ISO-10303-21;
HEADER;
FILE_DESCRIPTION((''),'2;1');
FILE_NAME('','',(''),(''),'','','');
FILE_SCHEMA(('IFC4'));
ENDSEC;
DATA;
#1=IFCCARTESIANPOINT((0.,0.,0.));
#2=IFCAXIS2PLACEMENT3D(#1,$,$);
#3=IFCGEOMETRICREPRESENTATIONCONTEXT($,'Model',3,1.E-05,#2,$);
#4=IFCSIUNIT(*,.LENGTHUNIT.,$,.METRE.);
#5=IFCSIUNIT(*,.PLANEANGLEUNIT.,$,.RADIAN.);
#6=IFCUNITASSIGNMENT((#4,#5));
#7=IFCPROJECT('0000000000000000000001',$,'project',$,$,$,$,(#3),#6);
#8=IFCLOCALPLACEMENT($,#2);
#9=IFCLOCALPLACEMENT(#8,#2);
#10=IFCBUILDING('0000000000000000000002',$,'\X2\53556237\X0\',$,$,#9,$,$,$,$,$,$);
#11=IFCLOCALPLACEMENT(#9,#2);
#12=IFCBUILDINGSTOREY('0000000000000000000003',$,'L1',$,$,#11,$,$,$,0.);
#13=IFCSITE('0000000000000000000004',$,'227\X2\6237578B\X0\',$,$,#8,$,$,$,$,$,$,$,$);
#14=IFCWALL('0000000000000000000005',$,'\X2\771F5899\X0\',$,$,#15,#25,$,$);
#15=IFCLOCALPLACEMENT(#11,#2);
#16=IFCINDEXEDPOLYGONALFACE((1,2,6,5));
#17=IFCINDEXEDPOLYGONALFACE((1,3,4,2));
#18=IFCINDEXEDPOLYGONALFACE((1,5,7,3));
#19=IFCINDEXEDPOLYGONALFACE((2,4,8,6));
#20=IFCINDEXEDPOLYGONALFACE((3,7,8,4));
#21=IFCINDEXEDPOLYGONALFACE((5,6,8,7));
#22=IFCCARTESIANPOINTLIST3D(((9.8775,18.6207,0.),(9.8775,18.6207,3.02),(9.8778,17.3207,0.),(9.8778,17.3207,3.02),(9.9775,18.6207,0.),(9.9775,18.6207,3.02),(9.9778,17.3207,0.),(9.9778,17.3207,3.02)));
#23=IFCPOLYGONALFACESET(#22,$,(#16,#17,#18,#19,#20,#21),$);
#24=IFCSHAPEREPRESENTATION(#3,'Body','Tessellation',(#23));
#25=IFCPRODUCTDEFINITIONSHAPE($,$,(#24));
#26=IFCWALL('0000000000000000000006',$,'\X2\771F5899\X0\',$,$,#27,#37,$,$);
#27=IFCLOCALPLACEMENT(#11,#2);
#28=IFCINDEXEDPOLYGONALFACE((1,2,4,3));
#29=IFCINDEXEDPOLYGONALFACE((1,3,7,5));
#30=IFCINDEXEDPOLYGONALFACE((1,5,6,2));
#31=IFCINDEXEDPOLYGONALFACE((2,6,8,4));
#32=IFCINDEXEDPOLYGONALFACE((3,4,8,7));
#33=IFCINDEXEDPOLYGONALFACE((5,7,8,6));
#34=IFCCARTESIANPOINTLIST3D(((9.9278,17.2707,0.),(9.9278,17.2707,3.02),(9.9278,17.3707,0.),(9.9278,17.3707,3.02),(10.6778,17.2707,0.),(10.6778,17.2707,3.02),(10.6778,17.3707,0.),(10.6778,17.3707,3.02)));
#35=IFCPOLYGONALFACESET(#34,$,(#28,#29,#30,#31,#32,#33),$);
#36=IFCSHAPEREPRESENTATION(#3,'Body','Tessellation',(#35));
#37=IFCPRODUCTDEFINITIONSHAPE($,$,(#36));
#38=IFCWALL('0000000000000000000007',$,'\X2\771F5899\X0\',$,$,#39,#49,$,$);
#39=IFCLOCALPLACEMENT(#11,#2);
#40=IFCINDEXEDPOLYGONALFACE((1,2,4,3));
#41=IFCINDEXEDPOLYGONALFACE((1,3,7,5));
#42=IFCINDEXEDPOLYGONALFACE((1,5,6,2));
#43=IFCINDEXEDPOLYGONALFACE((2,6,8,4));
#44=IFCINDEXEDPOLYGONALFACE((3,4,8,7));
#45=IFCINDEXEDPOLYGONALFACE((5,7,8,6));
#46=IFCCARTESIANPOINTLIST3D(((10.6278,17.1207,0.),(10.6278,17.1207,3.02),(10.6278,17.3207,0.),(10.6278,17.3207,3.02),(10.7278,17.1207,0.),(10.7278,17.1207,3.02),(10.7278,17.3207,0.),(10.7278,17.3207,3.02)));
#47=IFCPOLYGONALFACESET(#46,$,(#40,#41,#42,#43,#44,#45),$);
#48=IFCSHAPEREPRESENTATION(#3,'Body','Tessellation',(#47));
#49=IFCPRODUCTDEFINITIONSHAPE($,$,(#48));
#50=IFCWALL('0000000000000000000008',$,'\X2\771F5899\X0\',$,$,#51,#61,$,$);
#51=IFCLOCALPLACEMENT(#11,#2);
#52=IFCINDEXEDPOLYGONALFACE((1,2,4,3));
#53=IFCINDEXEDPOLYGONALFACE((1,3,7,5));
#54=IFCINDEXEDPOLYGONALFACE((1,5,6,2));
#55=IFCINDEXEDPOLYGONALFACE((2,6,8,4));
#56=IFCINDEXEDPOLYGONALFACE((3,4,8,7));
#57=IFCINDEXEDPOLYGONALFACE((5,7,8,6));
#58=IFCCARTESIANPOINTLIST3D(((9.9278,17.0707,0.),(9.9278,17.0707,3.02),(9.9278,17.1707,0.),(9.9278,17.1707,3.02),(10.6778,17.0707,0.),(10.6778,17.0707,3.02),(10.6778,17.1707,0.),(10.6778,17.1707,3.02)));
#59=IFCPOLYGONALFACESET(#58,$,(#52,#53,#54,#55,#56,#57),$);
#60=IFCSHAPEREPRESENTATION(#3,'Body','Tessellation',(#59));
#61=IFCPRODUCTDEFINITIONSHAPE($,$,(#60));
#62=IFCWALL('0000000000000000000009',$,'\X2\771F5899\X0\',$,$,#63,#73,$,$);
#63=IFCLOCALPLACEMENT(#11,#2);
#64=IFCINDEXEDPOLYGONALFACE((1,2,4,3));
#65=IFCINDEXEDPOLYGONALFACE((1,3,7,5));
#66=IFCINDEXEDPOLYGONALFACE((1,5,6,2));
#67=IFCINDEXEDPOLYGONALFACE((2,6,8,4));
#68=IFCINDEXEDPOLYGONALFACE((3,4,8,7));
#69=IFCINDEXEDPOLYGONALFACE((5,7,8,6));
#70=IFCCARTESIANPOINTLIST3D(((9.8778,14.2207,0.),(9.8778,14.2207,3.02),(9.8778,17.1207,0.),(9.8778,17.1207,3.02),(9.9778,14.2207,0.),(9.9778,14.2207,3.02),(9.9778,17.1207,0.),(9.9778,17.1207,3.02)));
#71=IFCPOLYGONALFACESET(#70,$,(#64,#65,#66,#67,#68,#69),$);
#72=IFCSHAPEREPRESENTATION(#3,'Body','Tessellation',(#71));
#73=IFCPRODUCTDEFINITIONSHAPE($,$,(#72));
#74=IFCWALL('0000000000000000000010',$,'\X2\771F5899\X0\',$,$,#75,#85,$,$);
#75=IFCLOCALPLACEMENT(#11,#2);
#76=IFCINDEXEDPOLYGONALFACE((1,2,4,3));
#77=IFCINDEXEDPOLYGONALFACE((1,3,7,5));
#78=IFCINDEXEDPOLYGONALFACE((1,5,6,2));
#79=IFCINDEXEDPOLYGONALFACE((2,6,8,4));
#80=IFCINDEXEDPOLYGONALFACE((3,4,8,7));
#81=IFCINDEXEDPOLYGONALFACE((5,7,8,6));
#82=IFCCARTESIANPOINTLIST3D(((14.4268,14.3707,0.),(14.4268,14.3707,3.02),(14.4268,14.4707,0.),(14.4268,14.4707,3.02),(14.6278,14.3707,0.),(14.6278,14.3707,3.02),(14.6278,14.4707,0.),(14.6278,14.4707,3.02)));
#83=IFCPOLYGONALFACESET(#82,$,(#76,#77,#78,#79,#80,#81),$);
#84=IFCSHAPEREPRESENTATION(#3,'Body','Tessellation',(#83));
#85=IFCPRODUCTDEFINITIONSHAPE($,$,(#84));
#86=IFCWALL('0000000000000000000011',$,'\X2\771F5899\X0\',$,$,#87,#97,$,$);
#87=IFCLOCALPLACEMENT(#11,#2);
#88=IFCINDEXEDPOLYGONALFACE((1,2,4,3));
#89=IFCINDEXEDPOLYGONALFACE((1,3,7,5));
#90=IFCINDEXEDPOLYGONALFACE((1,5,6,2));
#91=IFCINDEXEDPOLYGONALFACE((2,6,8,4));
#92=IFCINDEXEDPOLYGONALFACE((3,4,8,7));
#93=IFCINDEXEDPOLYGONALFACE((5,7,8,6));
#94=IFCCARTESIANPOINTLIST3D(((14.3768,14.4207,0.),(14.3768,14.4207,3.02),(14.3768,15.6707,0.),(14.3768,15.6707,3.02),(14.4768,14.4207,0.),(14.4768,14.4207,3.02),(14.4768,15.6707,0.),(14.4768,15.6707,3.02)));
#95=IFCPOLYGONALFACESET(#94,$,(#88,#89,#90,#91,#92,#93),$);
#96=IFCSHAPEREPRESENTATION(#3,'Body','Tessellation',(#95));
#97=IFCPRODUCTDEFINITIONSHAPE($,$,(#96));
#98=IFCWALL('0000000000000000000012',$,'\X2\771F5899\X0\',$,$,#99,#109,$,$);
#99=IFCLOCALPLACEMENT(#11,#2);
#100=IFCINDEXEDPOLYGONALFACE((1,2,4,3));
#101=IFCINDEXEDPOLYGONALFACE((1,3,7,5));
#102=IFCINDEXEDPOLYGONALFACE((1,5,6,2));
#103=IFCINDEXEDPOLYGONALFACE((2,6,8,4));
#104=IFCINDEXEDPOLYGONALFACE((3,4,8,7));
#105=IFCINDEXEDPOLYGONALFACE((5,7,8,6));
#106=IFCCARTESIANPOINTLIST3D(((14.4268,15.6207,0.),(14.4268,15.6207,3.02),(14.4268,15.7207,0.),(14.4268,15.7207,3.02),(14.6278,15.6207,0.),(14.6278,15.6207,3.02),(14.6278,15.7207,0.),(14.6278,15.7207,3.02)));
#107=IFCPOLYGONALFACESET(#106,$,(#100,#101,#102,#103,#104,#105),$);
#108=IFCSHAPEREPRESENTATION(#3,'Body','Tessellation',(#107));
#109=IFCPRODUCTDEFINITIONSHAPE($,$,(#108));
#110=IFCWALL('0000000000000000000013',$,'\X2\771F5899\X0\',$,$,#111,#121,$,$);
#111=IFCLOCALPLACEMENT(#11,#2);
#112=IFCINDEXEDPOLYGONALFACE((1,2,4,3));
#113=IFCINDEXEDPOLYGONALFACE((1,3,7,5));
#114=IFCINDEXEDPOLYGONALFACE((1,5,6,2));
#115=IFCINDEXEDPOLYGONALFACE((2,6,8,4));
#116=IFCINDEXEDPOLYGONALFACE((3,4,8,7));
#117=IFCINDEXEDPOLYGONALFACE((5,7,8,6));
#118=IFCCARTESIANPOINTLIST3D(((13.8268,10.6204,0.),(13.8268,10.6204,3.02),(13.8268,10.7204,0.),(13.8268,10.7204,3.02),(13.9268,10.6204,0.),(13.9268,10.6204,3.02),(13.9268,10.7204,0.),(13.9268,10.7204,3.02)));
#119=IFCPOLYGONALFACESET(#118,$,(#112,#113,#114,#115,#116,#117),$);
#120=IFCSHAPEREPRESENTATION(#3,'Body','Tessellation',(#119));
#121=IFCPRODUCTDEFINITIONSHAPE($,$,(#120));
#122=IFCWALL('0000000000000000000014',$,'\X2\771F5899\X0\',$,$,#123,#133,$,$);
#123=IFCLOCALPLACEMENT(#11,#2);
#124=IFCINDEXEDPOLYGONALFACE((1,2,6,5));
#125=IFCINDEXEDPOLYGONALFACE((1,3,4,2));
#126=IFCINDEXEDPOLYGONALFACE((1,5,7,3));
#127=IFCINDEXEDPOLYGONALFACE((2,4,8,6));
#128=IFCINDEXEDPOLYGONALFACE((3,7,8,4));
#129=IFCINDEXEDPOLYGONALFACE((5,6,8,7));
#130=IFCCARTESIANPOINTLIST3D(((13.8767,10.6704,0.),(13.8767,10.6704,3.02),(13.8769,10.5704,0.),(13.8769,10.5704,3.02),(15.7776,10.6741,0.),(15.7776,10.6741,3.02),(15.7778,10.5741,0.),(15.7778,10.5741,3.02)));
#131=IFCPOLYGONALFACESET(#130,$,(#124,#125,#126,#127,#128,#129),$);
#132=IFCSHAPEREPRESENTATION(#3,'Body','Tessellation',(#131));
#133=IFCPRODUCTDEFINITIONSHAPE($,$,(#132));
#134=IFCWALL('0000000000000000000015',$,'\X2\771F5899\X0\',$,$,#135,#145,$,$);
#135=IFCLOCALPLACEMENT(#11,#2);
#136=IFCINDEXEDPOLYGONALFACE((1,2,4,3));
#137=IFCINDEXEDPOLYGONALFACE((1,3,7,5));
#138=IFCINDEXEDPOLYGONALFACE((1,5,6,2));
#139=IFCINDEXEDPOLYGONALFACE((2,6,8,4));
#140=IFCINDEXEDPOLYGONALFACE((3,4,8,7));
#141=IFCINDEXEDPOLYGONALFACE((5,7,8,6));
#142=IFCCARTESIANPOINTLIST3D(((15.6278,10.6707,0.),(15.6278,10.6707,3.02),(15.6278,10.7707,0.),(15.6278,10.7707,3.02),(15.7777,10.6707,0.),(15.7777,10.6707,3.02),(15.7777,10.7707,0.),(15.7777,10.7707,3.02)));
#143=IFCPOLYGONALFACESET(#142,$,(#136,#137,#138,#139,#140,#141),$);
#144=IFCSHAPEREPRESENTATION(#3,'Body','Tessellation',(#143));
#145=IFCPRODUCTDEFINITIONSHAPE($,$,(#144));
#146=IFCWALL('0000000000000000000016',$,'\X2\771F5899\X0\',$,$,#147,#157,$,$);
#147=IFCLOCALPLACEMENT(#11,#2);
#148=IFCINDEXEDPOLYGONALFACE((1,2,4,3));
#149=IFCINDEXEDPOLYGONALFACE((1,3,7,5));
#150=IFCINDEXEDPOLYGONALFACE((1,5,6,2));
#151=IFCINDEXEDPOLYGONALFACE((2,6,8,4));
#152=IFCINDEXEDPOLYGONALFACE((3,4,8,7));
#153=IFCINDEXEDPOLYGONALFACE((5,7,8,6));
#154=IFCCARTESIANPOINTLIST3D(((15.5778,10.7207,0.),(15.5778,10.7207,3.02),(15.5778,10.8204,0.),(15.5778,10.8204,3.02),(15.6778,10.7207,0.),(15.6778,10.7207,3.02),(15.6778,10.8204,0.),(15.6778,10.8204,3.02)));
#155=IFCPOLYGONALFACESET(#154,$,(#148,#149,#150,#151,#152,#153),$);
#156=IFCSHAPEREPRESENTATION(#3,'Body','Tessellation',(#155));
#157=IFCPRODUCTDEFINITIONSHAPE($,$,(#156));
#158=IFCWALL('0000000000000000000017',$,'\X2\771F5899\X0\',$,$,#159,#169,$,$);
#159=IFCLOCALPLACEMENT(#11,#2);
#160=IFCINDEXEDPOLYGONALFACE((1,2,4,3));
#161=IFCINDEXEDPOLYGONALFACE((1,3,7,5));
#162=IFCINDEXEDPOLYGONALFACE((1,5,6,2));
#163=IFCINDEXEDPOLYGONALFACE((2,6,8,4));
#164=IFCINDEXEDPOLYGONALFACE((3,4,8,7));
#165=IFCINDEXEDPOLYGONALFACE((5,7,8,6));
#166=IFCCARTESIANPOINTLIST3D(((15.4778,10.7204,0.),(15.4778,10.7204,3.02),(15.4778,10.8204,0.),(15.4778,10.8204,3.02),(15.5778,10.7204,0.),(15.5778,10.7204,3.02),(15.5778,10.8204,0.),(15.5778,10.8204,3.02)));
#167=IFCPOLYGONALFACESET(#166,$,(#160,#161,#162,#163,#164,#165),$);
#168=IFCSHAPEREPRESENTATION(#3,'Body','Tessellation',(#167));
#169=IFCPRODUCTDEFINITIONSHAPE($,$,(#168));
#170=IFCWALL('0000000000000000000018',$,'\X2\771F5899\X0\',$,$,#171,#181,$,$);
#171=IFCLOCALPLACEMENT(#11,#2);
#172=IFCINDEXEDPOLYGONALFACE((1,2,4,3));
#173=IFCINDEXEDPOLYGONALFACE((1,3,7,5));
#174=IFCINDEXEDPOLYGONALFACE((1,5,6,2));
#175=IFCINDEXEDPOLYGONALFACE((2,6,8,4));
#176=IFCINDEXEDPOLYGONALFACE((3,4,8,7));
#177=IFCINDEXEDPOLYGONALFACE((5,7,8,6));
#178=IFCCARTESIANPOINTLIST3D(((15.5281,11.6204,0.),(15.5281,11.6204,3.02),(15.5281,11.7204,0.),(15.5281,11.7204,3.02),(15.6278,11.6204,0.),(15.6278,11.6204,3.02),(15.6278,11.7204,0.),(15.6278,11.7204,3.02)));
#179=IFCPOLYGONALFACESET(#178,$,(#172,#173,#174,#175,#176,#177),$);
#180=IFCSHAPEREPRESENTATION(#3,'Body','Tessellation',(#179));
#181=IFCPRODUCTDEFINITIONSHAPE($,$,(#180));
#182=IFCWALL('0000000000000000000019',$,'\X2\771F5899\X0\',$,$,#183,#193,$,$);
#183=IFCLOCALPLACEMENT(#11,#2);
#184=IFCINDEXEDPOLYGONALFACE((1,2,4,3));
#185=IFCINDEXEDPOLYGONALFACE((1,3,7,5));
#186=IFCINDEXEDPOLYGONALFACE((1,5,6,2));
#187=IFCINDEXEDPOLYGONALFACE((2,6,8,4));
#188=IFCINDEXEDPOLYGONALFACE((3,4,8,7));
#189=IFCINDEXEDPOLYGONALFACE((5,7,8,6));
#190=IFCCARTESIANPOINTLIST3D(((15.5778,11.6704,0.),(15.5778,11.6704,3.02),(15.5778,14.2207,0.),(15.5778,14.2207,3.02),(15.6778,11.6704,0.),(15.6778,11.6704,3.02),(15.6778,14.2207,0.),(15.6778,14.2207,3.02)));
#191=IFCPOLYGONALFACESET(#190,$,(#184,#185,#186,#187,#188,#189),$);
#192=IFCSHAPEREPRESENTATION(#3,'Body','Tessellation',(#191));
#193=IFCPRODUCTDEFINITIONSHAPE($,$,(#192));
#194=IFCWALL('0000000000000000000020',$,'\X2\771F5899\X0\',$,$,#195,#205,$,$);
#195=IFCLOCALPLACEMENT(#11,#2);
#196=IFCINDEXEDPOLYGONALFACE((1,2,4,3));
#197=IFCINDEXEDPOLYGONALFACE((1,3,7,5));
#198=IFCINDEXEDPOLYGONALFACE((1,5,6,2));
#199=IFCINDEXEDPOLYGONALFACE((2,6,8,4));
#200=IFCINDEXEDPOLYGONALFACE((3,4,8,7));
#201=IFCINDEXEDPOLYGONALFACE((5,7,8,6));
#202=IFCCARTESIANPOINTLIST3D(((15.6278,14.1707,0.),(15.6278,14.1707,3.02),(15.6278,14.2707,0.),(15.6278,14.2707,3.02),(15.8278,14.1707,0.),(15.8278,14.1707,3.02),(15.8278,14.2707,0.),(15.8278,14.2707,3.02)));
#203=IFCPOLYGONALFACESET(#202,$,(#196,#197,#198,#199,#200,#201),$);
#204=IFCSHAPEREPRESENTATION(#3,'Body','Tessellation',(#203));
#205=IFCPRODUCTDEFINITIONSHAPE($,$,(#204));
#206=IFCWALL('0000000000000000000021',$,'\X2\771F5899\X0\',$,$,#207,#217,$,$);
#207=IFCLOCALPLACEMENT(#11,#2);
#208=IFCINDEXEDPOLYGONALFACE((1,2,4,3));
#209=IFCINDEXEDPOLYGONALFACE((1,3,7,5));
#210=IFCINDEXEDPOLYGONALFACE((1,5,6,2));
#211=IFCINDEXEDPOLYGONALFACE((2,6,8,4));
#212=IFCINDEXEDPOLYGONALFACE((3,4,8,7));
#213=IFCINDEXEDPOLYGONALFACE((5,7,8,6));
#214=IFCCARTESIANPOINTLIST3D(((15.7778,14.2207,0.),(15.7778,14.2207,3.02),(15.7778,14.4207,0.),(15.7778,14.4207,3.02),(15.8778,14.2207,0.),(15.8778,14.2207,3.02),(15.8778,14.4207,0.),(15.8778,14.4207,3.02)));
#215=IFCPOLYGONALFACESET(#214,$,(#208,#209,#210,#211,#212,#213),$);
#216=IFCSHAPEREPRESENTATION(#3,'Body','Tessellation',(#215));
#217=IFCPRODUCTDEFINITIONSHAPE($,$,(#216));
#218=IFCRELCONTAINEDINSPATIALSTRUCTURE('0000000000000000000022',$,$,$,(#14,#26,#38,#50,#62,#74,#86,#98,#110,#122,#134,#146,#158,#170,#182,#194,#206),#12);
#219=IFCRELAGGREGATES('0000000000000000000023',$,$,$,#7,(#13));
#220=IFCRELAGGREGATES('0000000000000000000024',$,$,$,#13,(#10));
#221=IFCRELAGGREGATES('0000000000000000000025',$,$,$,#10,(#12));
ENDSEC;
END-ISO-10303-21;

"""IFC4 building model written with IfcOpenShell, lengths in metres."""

from ifc_helpers import new_model, si_unit, origin, place, context, project, spatial, polyline, outline, extrude, element, save


model = new_model("IFC4")

# Units and contexts
model_context = context("Model", 3, precision=1e-05, world=origin())
ifc_project = project(units=[si_unit("LENGTHUNIT", "METRE"), si_unit("PLANEANGLEUNIT", "RADIAN")], contexts=[model_context])

# Site, building, storey
site_placement = place(None, origin())
site = spatial("IfcSite", under=ifc_project, at=site_placement, Name="227户型")
building_placement = place(site_placement, origin())
building = spatial("IfcBuilding", under=site, at=building_placement, Name="单户")
storey_placement = place(building_placement, origin())
storey = spatial("IfcBuildingStorey", under=building, at=storey_placement, Name="L1", Elevation=0.0)

# Walls
wall_1_placement = place(storey_placement, origin())
element("IfcWall", 1, at=wall_1_placement, inside=storey, Name="真墙", context=model_context, shape_type="SweptSolid", body=[
    extrude(outline(polyline([(9.9775, 18.6207), (9.9778, 17.3207), (9.8778, 17.3207), (9.8775, 18.6207), (9.9775, 18.6207)])), origin(), (0.0, 0.0, 1.0), 3.02),
])
wall_2_placement = place(storey_placement, origin())
element("IfcWall", 2, at=wall_2_placement, inside=storey, Name="真墙", context=model_context, shape_type="SweptSolid", body=[
    extrude(outline(polyline([(9.9278, 17.3707), (10.6778, 17.3707), (10.6778, 17.2707), (9.9278, 17.2707), (9.9278, 17.3707)])), origin(), (0.0, 0.0, 1.0), 3.02),
])
wall_3_placement = place(storey_placement, origin())
element("IfcWall", 3, at=wall_3_placement, inside=storey, Name="真墙", context=model_context, shape_type="SweptSolid", body=[
    extrude(outline(polyline([(10.7278, 17.3207), (10.7278, 17.1207), (10.6278, 17.1207), (10.6278, 17.3207), (10.7278, 17.3207)])), origin(), (0.0, 0.0, 1.0), 3.02),
])
wall_4_placement = place(storey_placement, origin())
element("IfcWall", 4, at=wall_4_placement, inside=storey, Name="真墙", context=model_context, shape_type="SweptSolid", body=[
    extrude(outline(polyline([(10.6778, 17.0707), (9.9278, 17.0707), (9.9278, 17.1707), (10.6778, 17.1707), (10.6778, 17.0707)])), origin(), (0.0, 0.0, 1.0), 3.02),
])
wall_5_placement = place(storey_placement, origin())
element("IfcWall", 5, at=wall_5_placement, inside=storey, Name="真墙", context=model_context, shape_type="SweptSolid", body=[
    extrude(outline(polyline([(9.9778, 17.1207), (9.9778, 14.2207), (9.8778, 14.2207), (9.8778, 17.1207), (9.9778, 17.1207)])), origin(), (0.0, 0.0, 1.0), 3.02),
])
wall_6_placement = place(storey_placement, origin())
element("IfcWall", 6, at=wall_6_placement, inside=storey, Name="真墙", context=model_context, shape_type="SweptSolid", body=[
    extrude(outline(polyline([(14.6278, 14.3707), (14.4268, 14.3707), (14.4268, 14.4707), (14.6278, 14.4707), (14.6278, 14.3707)])), origin(), (0.0, 0.0, 1.0), 3.02),
])
wall_7_placement = place(storey_placement, origin())
element("IfcWall", 7, at=wall_7_placement, inside=storey, Name="真墙", context=model_context, shape_type="SweptSolid", body=[
    extrude(outline(polyline([(14.3768, 14.4207), (14.3768, 15.6707), (14.4768, 15.6707), (14.4768, 14.4207), (14.3768, 14.4207)])), origin(), (0.0, 0.0, 1.0), 3.02),
])
wall_8_placement = place(storey_placement, origin())
element("IfcWall", 8, at=wall_8_placement, inside=storey, Name="真墙", context=model_context, shape_type="SweptSolid", body=[
    extrude(outline(polyline([(14.4268, 15.7207), (14.6278, 15.7207), (14.6278, 15.6207), (14.4268, 15.6207), (14.4268, 15.7207)])), origin(), (0.0, 0.0, 1.0), 3.02),
])
wall_9_placement = place(storey_placement, origin())
element("IfcWall", 9, at=wall_9_placement, inside=storey, Name="真墙", context=model_context, shape_type="SweptSolid", body=[
    extrude(outline(polyline([(13.9268, 10.7204), (13.9268, 10.6204), (13.8268, 10.6204), (13.8268, 10.7204), (13.9268, 10.7204)])), origin(), (0.0, 0.0, 1.0), 3.02),
])
wall_10_placement = place(storey_placement, origin())
element("IfcWall", 10, at=wall_10_placement, inside=storey, Name="真墙", context=model_context, shape_type="SweptSolid", body=[
    extrude(outline(polyline([(13.8767, 10.6704), (15.7776, 10.6741), (15.7778, 10.5741), (13.8769, 10.5704), (13.8767, 10.6704)])), origin(), (0.0, 0.0, 1.0), 3.02),
])

# Walls
wall_11_placement = place(storey_placement, origin())
element("IfcWall", 11, at=wall_11_placement, inside=storey, Name="真墙", context=model_context, shape_type="SweptSolid", body=[
    extrude(outline(polyline([(15.7777, 10.6707), (15.6278, 10.6707), (15.6278, 10.7707), (15.7777, 10.7707), (15.7777, 10.6707)])), origin(), (0.0, 0.0, 1.0), 3.02),
])
wall_12_placement = place(storey_placement, origin())
element("IfcWall", 12, at=wall_12_placement, inside=storey, Name="真墙", context=model_context, shape_type="SweptSolid", body=[
    extrude(outline(polyline([(15.5778, 10.7207), (15.5778, 10.8204), (15.6778, 10.8204), (15.6778, 10.7207), (15.5778, 10.7207)])), origin(), (0.0, 0.0, 1.0), 3.02),
])

# Walls
wall_13_placement = place(storey_placement, origin())
element("IfcWall", 13, at=wall_13_placement, inside=storey, Name="真墙", context=model_context, shape_type="SweptSolid", body=[
    extrude(outline(polyline([(15.5778, 10.8204), (15.5778, 10.7204), (15.4778, 10.7204), (15.4778, 10.8204), (15.5778, 10.8204)])), origin(), (0.0, 0.0, 1.0), 3.02),
])
wall_14_placement = place(storey_placement, origin())
element("IfcWall", 14, at=wall_14_placement, inside=storey, Name="真墙", context=model_context, shape_type="SweptSolid", body=[
    extrude(outline(polyline([(15.5281, 11.7204), (15.6278, 11.7204), (15.6278, 11.6204), (15.5281, 11.6204), (15.5281, 11.7204)])), origin(), (0.0, 0.0, 1.0), 3.02),
])
wall_15_placement = place(storey_placement, origin())
element("IfcWall", 15, at=wall_15_placement, inside=storey, Name="真墙", context=model_context, shape_type="SweptSolid", body=[
    extrude(outline(polyline([(15.5778, 11.6704), (15.5778, 14.2207), (15.6778, 14.2207), (15.6778, 11.6704), (15.5778, 11.6704)])), origin(), (0.0, 0.0, 1.0), 3.02),
])
wall_16_placement = place(storey_placement, origin())
element("IfcWall", 16, at=wall_16_placement, inside=storey, Name="真墙", context=model_context, shape_type="SweptSolid", body=[
    extrude(outline(polyline([(15.6278, 14.2707), (15.8278, 14.2707), (15.8278, 14.1707), (15.6278, 14.1707), (15.6278, 14.2707)])), origin(), (0.0, 0.0, 1.0), 3.02),
])
wall_17_placement = place(storey_placement, origin())
element("IfcWall", 17, at=wall_17_placement, inside=storey, Name="真墙", context=model_context, shape_type="SweptSolid", body=[
    extrude(outline(polyline([(15.7778, 14.2207), (15.7778, 14.4207), (15.8778, 14.4207), (15.8778, 14.2207), (15.7778, 14.2207)])), origin(), (0.0, 0.0, 1.0), 3.02),
])

save(model, "model.ifc")
